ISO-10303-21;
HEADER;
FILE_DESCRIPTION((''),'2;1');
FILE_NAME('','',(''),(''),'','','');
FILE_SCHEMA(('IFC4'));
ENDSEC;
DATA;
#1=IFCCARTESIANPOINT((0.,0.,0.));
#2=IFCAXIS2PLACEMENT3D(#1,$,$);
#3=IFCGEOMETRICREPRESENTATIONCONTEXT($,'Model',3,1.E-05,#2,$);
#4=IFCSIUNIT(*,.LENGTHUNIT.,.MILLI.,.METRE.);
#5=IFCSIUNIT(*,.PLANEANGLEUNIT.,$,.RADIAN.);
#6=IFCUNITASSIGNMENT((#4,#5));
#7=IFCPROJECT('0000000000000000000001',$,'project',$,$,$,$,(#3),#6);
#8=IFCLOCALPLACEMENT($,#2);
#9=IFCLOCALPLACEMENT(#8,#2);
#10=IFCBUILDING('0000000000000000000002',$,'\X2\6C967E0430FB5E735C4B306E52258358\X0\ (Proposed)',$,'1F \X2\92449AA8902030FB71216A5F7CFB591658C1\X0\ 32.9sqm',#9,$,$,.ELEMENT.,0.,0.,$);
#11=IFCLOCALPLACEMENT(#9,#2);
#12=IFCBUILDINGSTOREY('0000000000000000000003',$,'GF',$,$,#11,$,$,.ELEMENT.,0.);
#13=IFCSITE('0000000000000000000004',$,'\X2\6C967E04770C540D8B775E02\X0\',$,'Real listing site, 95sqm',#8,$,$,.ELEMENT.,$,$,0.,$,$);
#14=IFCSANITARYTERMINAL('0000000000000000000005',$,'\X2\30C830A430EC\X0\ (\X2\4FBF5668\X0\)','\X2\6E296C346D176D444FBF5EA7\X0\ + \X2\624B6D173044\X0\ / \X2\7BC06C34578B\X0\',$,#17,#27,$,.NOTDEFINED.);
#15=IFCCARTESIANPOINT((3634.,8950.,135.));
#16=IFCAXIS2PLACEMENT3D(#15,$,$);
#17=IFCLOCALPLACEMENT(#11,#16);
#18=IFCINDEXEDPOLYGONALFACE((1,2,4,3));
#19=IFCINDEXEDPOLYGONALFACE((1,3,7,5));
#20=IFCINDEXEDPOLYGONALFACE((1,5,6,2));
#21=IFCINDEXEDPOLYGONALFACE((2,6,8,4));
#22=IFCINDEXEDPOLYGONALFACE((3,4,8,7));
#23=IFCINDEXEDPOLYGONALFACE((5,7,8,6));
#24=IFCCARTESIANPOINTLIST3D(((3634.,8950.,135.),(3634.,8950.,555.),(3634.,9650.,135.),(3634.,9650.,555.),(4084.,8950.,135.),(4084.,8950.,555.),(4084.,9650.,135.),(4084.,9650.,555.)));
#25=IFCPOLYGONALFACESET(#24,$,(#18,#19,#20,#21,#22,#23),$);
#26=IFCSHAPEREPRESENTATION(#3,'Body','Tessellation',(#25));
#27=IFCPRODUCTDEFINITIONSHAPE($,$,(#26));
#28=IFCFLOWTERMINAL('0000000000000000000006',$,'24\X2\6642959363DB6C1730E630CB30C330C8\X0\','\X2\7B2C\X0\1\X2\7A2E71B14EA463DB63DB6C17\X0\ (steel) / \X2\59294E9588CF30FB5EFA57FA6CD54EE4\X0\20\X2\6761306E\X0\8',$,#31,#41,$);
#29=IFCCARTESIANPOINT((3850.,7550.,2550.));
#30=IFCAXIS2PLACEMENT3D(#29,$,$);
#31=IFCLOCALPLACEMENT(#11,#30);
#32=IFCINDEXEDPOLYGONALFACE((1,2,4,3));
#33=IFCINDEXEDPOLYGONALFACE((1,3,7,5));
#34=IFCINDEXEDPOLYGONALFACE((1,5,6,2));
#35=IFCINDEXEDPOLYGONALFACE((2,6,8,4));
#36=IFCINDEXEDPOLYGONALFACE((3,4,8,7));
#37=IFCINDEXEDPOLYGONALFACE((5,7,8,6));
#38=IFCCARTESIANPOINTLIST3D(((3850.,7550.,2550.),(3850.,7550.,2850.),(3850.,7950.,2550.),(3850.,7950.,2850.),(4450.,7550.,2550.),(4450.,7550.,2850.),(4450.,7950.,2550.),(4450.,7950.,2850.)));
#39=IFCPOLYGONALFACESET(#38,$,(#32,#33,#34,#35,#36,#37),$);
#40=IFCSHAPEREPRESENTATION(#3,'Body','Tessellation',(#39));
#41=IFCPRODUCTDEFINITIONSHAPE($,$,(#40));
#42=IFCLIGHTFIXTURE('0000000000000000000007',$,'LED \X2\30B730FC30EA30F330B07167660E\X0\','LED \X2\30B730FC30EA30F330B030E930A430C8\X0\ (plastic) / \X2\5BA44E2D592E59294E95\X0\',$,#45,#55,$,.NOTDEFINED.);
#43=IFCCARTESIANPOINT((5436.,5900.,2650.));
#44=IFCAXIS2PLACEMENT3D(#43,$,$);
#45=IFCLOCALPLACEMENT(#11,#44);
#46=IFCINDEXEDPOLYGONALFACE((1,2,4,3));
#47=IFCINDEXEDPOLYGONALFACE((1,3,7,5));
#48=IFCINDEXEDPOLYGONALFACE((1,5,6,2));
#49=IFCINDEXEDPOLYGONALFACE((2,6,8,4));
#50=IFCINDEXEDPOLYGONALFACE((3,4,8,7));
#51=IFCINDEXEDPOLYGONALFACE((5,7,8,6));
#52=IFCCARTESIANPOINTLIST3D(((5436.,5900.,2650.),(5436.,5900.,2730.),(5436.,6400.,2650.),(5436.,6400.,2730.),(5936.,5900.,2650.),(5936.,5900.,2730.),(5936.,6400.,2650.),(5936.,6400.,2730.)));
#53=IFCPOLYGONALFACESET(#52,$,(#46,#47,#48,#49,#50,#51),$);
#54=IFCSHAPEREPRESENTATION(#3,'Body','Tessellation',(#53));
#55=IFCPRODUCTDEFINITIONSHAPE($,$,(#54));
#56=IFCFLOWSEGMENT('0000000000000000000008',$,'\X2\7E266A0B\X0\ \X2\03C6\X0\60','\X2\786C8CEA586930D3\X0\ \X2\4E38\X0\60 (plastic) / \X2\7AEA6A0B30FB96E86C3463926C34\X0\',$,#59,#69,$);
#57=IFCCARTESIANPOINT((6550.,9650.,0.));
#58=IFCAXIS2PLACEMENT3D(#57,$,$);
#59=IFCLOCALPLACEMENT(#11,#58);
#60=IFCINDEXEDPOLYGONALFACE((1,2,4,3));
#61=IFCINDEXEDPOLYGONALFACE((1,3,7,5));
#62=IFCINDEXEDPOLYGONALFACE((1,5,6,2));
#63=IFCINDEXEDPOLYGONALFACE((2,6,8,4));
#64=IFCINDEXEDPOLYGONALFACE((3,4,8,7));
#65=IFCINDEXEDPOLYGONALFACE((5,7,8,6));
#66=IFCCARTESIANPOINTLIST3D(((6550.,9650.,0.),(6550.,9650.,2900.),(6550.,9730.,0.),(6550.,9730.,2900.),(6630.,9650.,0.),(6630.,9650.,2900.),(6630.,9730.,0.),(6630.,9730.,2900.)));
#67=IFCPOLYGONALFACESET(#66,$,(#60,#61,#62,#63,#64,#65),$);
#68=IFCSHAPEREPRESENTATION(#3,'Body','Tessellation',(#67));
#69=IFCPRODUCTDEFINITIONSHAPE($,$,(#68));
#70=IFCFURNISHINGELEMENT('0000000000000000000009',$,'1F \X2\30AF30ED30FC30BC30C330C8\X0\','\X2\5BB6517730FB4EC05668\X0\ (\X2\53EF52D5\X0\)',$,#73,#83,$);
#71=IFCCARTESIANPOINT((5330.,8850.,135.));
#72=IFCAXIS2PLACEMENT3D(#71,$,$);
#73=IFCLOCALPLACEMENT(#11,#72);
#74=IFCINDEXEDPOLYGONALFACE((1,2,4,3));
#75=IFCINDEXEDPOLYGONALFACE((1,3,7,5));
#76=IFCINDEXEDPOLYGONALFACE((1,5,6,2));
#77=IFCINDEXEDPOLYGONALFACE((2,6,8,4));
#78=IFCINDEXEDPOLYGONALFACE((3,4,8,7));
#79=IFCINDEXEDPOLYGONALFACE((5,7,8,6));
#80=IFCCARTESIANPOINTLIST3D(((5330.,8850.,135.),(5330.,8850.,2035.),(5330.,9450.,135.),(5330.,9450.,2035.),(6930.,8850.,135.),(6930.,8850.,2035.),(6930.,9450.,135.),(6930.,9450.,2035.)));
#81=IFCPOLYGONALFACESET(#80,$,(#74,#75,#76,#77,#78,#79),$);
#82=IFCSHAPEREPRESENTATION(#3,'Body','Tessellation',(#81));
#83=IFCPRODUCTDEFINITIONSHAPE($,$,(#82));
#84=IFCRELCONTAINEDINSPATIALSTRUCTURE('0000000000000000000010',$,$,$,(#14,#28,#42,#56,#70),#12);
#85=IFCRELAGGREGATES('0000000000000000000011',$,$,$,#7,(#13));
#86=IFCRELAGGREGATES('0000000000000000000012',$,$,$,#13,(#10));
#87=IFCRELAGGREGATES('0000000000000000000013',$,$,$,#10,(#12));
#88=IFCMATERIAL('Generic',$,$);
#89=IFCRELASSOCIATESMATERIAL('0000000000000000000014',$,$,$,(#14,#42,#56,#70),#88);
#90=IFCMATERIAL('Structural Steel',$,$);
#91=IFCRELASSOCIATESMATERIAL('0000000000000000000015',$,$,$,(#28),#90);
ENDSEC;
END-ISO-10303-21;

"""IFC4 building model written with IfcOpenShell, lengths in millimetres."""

from ifc_helpers import new_model, si_unit, frame, frame_2d, origin, place, context, project, spatial, rectangle, extrude, material, element, save


model = new_model("IFC4")

# Units and contexts
model_context = context("Model", 3, precision=1e-05, world=origin())
ifc_project = project(units=[si_unit("LENGTHUNIT", "METRE", prefix="MILLI"), si_unit("PLANEANGLEUNIT", "RADIAN")], contexts=[model_context])

# Site, building, storey
site_placement = place(None, origin())
site = spatial("IfcSite", under=ifc_project, at=site_placement, Name="沖縄県名護市", ObjectType="Real listing site, 95sqm", CompositionType="ELEMENT", RefElevation=0.0)
building_placement = place(site_placement, origin())
building = spatial("IfcBuilding", under=site, at=building_placement, Name="沖縄・平屋の別荘 (Proposed)", ObjectType="1F 鉄骨造・無機系外壁 32.9sqm", CompositionType="ELEMENT", ElevationOfRefHeight=0.0, ElevationOfTerrain=0.0)
storey_placement = place(building_placement, origin())
storey = spatial("IfcBuildingStorey", under=building, at=storey_placement, Name="GF", CompositionType="ELEMENT", Elevation=0.0)

# Shared definitions
ifc_material_1 = material(Name="Generic")

# Sanitary terminal
sanitary_terminal_1_placement = place(storey_placement, frame((3634.0, 8950.0, 135.0)))
element("IfcSanitaryTerminal", 1, at=sanitary_terminal_1_placement, inside=storey, material=ifc_material_1, Name="トイレ (便器)", Description="温水洗浄便座 + 手洗い / 節水型", PredefinedType="NOTDEFINED", context=model_context, shape_type="SweptSolid", body=[
    extrude(rectangle(XDim=450.0, YDim=700.0, at=frame_2d((225.0, 350.0))), frame((3634.0, 8950.0, 135.0)), (0.0, 0.0, 1.0), 420.0),
])

# Flow terminal
ifc_material_2 = material(Name="Structural Steel")
flow_terminal_placement = place(storey_placement, frame((3850.0, 7550.0, 2550.0)))
element("IfcFlowTerminal", 2, at=flow_terminal_placement, inside=storey, material=ifc_material_2, Name="24時間換気ユニット", Description="第1種熱交換換気 (steel) / 天井裏・建基法令20条の8", context=model_context, shape_type="SweptSolid", body=[
    extrude(rectangle(XDim=600.0, YDim=400.0, at=frame_2d((300.0, 200.0))), frame((3850.0, 7550.0, 2550.0)), (0.0, 0.0, 1.0), 300.0),
])

# Light fixture
light_fixture_placement = place(storey_placement, frame((5436.0, 5900.0, 2650.0)))
element("IfcLightFixture", 3, at=light_fixture_placement, inside=storey, material=ifc_material_1, Name="LED シーリング照明", Description="LED シーリングライト (plastic) / 室中央天井", PredefinedType="NOTDEFINED", context=model_context, shape_type="SweptSolid", body=[
    extrude(rectangle(XDim=500.0, YDim=500.0, at=frame_2d((250.0, 250.0))), frame((5436.0, 5900.0, 2650.0)), (0.0, 0.0, 1.0), 80.0),
])

# Flow segment
flow_segment_placement = place(storey_placement, frame((6550.0, 9650.0, 0.0)))
element("IfcFlowSegment", 4, at=flow_segment_placement, inside=storey, material=ifc_material_1, Name="縦樋 φ60", Description="硬質塩ビ 丸60 (plastic) / 竪樋・雨水排水", context=model_context, shape_type="SweptSolid", body=[
    extrude(rectangle(XDim=80.0, YDim=80.0, at=frame_2d((40.0, 40.0))), frame((6550.0, 9650.0, 0.0)), (0.0, 0.0, 1.0), 2900.0),
])

# Furnishing element
furnishing_placement = place(storey_placement, frame((5330.0, 8850.0, 135.0)))
element("IfcFurnishingElement", 5, at=furnishing_placement, inside=storey, material=ifc_material_1, Name="1F クローゼット", Description="家具・什器 (可動)", context=model_context, shape_type="SweptSolid", body=[
    extrude(rectangle(XDim=1600.0, YDim=600.0, at=frame_2d((800.0, 300.0))), frame((5330.0, 8850.0, 135.0)), (0.0, 0.0, 1.0), 1900.0),
])

save(model, "model.ifc")
